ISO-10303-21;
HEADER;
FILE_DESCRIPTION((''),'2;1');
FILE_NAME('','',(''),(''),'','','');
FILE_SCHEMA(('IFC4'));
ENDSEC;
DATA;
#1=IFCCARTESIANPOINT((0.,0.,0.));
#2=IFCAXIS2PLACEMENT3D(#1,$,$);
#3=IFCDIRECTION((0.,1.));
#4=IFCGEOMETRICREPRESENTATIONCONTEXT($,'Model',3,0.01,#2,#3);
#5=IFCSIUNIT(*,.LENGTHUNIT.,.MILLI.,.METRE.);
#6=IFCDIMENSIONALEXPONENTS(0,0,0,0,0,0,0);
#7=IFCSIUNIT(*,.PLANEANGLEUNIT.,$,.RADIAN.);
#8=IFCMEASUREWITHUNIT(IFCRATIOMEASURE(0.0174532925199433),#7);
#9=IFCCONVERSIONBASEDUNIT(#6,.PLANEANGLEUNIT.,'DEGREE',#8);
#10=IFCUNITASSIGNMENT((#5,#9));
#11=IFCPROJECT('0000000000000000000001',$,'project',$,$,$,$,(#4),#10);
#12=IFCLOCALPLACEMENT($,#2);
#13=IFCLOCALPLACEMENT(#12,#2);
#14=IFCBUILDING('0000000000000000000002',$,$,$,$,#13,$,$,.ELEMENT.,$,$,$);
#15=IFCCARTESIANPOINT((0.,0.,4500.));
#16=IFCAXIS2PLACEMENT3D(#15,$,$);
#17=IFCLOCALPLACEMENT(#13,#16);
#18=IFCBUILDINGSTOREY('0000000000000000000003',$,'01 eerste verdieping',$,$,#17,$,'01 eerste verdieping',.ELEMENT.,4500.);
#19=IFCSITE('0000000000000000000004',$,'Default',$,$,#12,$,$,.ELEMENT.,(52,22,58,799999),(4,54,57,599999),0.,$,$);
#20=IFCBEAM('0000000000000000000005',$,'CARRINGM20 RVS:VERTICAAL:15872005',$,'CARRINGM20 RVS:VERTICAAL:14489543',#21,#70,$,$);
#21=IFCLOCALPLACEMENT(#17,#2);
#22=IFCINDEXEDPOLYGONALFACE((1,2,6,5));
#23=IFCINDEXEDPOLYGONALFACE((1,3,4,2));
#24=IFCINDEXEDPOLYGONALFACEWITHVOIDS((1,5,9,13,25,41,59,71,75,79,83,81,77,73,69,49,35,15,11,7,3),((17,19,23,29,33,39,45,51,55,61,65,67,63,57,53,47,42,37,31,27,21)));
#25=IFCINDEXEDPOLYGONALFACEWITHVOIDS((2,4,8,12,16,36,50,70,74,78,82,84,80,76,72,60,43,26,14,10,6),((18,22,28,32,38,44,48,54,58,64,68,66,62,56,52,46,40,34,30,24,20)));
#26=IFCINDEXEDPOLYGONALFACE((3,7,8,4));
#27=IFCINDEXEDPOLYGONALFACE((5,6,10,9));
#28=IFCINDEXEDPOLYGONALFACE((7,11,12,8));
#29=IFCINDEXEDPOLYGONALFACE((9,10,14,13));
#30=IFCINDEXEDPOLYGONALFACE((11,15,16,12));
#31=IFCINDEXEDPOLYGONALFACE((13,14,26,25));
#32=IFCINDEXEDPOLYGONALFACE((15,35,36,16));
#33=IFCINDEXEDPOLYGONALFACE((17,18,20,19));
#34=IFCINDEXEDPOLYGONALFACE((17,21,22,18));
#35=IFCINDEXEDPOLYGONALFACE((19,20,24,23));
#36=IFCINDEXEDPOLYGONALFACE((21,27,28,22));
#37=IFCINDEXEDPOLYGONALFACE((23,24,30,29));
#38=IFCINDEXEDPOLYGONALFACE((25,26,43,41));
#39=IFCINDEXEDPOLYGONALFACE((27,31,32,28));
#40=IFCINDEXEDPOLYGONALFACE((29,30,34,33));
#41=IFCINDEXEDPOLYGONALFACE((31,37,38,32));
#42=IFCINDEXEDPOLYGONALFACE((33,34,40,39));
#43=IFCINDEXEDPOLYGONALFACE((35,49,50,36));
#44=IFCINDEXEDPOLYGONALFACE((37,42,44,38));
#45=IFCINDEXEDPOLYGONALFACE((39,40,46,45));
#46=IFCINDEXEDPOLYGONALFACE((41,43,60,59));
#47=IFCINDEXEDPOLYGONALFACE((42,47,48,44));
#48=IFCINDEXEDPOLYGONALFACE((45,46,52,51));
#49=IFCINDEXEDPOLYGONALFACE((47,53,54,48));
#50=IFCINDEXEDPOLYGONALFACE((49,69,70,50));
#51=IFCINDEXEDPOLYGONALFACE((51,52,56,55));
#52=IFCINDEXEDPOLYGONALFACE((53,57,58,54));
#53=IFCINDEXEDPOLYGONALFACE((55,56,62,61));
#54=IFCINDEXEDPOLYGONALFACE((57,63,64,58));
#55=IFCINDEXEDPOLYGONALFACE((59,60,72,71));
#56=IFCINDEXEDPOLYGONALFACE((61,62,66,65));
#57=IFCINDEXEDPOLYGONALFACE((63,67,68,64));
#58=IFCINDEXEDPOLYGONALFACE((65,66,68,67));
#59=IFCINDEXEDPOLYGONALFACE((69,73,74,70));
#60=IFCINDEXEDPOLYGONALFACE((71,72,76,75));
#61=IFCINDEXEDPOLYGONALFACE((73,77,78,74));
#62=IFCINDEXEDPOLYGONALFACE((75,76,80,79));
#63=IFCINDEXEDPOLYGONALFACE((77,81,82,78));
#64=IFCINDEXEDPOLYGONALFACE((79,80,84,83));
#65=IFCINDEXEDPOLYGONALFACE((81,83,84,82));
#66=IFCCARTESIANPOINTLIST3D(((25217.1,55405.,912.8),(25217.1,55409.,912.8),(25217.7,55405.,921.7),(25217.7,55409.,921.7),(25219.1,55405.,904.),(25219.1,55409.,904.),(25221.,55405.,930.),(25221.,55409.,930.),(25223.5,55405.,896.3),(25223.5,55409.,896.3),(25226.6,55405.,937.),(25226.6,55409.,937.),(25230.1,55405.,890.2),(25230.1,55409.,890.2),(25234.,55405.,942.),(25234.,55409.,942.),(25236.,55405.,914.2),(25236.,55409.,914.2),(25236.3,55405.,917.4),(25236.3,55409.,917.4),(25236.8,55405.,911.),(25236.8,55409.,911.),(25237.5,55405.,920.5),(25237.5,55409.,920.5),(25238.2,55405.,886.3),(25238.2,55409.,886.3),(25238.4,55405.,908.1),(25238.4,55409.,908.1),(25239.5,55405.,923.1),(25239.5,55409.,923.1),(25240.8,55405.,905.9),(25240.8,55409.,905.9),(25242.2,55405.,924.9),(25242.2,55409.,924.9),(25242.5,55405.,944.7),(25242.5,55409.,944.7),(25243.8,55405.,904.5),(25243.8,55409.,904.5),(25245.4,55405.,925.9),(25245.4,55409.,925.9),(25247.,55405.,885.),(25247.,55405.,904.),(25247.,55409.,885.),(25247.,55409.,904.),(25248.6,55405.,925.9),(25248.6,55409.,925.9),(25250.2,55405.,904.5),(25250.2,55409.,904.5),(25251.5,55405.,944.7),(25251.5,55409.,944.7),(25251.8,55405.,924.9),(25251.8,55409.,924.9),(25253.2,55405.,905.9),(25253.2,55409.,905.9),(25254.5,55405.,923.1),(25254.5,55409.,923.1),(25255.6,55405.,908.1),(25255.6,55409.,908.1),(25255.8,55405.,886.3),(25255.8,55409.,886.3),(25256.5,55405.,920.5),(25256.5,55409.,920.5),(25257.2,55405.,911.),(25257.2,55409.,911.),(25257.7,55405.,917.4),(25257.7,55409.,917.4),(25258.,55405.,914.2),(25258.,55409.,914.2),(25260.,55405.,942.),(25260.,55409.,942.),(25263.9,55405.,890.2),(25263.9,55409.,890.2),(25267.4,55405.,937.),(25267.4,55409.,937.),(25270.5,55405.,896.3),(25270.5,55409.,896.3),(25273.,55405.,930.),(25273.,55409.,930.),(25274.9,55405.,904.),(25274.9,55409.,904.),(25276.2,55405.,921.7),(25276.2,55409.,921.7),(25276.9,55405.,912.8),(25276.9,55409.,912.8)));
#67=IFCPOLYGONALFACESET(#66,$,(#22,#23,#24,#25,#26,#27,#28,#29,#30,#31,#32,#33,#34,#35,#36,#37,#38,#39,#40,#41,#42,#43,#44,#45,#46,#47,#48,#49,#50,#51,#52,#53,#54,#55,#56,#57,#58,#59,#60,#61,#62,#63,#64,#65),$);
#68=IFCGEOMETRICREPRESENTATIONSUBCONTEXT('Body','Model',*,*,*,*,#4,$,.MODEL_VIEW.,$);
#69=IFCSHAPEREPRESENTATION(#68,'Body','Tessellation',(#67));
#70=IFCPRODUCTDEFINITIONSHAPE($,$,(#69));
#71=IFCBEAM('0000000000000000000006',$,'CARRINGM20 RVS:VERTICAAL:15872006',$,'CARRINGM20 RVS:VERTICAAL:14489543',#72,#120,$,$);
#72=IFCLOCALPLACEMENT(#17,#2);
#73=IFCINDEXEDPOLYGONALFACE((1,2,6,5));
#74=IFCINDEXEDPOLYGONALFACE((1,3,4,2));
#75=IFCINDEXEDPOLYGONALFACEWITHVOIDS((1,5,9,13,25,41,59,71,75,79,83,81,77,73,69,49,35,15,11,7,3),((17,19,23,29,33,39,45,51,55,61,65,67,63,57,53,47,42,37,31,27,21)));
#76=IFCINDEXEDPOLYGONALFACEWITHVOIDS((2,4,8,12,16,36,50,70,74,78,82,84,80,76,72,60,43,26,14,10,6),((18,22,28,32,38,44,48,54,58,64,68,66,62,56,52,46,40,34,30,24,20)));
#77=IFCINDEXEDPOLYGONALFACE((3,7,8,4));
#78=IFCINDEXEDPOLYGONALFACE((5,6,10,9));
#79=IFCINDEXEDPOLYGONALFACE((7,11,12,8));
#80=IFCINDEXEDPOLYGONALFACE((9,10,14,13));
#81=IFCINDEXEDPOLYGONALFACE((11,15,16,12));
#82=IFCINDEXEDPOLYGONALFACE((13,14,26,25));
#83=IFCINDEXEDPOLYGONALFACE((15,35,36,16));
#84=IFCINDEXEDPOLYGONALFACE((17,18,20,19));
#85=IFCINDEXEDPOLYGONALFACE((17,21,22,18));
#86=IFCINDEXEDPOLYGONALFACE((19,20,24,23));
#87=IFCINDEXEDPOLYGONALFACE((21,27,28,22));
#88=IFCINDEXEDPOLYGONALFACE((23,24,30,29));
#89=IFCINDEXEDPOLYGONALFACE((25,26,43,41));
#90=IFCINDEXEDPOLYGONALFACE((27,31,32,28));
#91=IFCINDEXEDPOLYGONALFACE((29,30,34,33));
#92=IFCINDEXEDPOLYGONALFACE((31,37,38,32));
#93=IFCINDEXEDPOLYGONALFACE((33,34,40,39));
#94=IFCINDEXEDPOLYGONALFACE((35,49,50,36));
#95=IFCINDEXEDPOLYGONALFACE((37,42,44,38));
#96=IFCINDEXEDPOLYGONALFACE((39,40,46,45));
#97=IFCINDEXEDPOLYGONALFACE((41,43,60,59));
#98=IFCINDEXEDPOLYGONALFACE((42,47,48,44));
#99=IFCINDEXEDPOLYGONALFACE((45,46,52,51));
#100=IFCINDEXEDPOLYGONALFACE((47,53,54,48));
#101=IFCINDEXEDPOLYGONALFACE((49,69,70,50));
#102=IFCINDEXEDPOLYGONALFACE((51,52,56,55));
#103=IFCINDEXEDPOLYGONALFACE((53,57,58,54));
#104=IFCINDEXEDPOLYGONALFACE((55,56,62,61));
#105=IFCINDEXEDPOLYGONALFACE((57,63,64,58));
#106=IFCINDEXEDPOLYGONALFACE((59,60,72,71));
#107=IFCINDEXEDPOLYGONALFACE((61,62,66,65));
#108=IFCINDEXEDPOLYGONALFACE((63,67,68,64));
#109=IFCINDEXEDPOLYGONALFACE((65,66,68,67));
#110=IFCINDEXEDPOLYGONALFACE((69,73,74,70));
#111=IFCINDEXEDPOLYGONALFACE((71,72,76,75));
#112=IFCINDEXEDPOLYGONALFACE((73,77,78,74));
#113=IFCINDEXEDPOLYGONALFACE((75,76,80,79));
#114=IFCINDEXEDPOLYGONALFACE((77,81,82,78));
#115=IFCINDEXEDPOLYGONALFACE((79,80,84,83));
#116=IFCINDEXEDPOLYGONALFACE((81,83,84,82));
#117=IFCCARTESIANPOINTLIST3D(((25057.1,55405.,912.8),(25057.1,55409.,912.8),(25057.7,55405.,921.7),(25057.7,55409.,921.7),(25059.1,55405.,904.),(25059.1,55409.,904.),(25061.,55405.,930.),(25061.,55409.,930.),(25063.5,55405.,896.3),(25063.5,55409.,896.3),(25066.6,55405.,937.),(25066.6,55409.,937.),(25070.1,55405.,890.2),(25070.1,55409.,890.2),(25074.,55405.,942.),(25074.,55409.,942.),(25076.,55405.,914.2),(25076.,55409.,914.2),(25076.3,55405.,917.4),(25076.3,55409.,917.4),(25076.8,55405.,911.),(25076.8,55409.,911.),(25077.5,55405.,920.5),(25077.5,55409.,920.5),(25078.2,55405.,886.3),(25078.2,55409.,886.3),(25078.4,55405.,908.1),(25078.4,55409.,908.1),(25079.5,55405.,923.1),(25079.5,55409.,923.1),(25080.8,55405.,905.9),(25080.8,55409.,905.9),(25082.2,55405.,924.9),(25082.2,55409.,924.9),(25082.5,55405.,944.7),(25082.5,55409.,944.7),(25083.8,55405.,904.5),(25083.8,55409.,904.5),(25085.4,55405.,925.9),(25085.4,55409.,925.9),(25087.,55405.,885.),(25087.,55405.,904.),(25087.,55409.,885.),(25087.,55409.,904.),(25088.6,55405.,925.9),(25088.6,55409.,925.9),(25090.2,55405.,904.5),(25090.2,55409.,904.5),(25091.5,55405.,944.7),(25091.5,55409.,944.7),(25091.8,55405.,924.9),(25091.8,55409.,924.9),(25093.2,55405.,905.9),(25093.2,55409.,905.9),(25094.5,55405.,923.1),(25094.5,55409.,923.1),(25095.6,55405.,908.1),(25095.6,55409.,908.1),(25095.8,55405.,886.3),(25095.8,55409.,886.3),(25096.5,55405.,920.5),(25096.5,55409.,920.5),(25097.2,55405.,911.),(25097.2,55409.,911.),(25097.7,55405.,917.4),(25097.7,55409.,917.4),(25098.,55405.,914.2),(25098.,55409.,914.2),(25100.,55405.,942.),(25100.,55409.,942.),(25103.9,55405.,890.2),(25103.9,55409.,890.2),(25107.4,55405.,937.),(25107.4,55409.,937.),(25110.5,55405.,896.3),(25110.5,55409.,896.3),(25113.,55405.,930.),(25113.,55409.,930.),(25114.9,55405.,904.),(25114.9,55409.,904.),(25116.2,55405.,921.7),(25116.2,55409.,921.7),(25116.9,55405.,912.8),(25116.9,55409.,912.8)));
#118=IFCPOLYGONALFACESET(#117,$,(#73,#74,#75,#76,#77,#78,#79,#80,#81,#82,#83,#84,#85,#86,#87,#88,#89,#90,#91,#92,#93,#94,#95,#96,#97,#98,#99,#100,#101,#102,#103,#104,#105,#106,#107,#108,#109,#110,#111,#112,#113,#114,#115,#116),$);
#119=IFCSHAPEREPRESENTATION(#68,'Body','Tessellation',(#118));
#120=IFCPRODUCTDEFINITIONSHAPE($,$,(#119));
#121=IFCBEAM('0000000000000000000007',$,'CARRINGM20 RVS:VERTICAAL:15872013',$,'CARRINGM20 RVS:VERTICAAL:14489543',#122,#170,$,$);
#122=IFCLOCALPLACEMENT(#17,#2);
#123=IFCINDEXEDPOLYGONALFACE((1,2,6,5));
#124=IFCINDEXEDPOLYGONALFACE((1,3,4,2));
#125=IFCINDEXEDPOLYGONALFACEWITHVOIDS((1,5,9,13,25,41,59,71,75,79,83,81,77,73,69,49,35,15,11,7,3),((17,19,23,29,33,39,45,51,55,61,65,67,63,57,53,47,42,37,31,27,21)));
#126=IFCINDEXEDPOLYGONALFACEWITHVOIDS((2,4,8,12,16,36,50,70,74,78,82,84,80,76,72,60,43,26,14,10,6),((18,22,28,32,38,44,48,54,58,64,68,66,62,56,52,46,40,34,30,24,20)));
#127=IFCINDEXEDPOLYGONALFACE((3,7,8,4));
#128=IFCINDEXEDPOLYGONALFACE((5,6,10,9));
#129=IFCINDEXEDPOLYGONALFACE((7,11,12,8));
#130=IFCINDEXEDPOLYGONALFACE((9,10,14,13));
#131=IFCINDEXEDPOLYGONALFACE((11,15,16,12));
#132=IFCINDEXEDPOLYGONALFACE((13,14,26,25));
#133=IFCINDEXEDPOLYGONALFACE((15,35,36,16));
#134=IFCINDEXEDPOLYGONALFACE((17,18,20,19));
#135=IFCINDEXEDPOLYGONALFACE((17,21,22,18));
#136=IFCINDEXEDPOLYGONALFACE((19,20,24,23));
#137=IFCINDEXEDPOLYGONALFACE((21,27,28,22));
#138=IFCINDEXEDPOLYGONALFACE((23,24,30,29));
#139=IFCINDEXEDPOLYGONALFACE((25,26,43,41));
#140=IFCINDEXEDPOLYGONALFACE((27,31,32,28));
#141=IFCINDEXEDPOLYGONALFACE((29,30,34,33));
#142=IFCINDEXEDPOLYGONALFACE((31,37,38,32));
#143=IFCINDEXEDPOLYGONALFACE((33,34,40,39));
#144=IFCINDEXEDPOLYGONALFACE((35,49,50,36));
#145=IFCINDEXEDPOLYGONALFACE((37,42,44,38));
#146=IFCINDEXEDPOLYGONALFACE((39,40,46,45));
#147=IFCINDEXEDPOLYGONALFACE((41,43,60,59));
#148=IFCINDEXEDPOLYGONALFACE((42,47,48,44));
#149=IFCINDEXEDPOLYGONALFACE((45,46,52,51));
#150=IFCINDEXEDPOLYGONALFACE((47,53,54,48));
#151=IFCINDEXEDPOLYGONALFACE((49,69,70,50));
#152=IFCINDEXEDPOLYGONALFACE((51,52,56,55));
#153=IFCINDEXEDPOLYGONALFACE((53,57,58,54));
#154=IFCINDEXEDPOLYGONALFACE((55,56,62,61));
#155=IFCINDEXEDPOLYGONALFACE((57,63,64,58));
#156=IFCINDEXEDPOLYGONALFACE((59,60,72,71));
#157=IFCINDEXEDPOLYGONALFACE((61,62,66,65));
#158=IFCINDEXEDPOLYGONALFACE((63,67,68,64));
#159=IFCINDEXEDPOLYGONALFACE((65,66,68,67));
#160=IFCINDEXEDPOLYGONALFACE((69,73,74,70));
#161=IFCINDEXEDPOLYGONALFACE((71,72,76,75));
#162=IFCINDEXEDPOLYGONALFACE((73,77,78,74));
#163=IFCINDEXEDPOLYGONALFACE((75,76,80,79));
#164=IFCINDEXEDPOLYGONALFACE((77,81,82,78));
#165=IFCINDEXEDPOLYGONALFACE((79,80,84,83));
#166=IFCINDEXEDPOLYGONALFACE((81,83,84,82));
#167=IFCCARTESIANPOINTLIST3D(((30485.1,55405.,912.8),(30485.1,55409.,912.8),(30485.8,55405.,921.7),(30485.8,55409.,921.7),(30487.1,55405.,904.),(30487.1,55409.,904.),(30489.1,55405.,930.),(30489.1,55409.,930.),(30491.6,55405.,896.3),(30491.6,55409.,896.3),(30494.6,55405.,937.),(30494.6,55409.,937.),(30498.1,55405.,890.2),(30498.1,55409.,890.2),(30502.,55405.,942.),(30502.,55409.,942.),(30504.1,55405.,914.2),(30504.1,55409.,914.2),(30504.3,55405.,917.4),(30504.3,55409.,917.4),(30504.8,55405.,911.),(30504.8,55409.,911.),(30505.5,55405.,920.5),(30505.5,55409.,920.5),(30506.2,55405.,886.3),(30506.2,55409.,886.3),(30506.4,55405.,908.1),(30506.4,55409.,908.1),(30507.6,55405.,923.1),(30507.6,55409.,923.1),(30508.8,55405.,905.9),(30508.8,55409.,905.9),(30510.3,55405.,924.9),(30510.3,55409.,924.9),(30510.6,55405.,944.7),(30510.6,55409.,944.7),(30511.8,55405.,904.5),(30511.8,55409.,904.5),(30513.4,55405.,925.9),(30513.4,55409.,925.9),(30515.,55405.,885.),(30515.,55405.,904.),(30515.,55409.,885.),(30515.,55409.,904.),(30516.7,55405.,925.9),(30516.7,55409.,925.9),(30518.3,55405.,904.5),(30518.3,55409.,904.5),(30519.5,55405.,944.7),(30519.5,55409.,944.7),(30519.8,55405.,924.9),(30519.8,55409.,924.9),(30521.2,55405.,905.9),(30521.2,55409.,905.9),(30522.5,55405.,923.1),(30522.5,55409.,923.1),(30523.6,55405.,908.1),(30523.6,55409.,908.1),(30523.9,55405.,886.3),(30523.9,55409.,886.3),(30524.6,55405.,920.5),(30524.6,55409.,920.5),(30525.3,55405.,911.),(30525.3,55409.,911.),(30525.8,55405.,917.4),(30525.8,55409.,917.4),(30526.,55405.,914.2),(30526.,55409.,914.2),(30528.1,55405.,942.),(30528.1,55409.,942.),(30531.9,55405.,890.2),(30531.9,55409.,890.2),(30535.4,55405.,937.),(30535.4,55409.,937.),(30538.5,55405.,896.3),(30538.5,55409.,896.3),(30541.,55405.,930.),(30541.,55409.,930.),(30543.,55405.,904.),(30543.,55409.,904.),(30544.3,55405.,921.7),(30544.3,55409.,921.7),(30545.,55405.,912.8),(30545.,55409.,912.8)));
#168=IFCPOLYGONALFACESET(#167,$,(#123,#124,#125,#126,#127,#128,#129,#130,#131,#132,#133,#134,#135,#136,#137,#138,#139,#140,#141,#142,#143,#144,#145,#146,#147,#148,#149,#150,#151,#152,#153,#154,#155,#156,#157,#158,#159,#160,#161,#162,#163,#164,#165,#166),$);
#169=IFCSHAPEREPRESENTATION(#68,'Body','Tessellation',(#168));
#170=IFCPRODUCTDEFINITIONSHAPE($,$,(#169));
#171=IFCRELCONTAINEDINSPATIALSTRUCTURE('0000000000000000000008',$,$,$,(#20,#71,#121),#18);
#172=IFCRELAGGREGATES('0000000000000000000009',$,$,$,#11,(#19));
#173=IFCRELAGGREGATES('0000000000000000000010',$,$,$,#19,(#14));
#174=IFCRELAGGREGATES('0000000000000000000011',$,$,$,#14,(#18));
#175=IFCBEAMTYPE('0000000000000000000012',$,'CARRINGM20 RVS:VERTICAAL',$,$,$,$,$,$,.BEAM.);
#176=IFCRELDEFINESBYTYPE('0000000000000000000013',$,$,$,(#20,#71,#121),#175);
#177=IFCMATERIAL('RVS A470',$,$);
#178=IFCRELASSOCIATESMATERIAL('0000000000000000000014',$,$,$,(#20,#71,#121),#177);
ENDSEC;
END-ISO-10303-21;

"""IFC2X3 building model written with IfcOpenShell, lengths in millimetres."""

from ifc_helpers import new_model, entity, si_unit, converted_unit, direction, frame, origin, origin_2d_with_axis, place, context, subcontext, project, spatial, hollow_circle, extrude, material, type_object, element, save


model = new_model("IFC2X3")

# Units and contexts
model_context = context("Model", 3, precision=0.01, world=origin(), true_north=direction((0.0, 1.0)))
body_context = subcontext(model_context, "Body", "Model", "MODEL_VIEW")
ifc_project = project(units=[si_unit("LENGTHUNIT", "METRE", prefix="MILLI"), converted_unit("PLANEANGLEUNIT", "DEGREE", entity("IfcRatioMeasure", 0.0174532925199433), si_unit("PLANEANGLEUNIT", "RADIAN"), dimensions=[0, 0, 0, 0, 0, 0, 0])], contexts=[model_context])

# Site, building, storey
site_placement = place(None, origin())
site = spatial("IfcSite", under=ifc_project, at=site_placement, Name="Default", CompositionType="ELEMENT", RefLatitude=(52, 22, 58, 799999), RefLongitude=(4, 54, 57, 599999), RefElevation=0.0)
building_placement = place(site_placement, origin())
building = spatial("IfcBuilding", under=site, at=building_placement, CompositionType="ELEMENT")
storey_placement = place(building_placement, frame((0.0, 0.0, 4500.0)))
storey = spatial("IfcBuildingStorey", under=building, at=storey_placement, Name="01 eerste verdieping", LongName="01 eerste verdieping", CompositionType="ELEMENT", Elevation=4500.0)

# Beams
ifc_material_1 = material(Name="RVS A470")
beam_type_1 = type_object("IfcBeamType", Name="CARRINGM20 RVS:VERTICAAL", PredefinedType="BEAM")
beam_1_placement = place(storey_placement, origin())
element("IfcBeam", 1, at=beam_1_placement, inside=storey, type_object=beam_type_1, material=ifc_material_1, Name="CARRINGM20 RVS:VERTICAAL:15872005", ObjectType="CARRINGM20 RVS:VERTICAAL:14489543", context=body_context, shape_type="SweptSolid", body=[
    extrude(hollow_circle(Radius=30.0, WallThickness=19.0, at=origin_2d_with_axis()), frame((25247.0, 55405.0, 915.0), z_axis=(0.0, 1.0, 0.0), x_axis=(0.0, 0.0, -1.0)), (0.0, 0.0, 1.0), 4.0),
])
beam_2_placement = place(storey_placement, origin())
element("IfcBeam", 2, at=beam_2_placement, inside=storey, type_object=beam_type_1, material=ifc_material_1, Name="CARRINGM20 RVS:VERTICAAL:15872006", ObjectType="CARRINGM20 RVS:VERTICAAL:14489543", context=body_context, shape_type="SweptSolid", body=[
    extrude(hollow_circle(Radius=30.0, WallThickness=19.0, at=origin_2d_with_axis()), frame((25087.0, 55405.0, 915.0), z_axis=(0.0, 1.0, 0.0), x_axis=(0.0, 0.0, -1.0)), (0.0, 0.0, 1.0), 4.0),
])
beam_3_placement = place(storey_placement, origin())
element("IfcBeam", 3, at=beam_3_placement, inside=storey, type_object=beam_type_1, material=ifc_material_1, Name="CARRINGM20 RVS:VERTICAAL:15872013", ObjectType="CARRINGM20 RVS:VERTICAAL:14489543", context=body_context, shape_type="SweptSolid", body=[
    extrude(hollow_circle(Radius=30.0, WallThickness=19.0, at=origin_2d_with_axis()), frame((30515.0, 55405.0, 915.0), z_axis=(0.0, 1.0, 0.0), x_axis=(0.0, 0.0, -1.0)), (0.0, 0.0, 1.0), 4.0),
])

save(model, "model.ifc")
